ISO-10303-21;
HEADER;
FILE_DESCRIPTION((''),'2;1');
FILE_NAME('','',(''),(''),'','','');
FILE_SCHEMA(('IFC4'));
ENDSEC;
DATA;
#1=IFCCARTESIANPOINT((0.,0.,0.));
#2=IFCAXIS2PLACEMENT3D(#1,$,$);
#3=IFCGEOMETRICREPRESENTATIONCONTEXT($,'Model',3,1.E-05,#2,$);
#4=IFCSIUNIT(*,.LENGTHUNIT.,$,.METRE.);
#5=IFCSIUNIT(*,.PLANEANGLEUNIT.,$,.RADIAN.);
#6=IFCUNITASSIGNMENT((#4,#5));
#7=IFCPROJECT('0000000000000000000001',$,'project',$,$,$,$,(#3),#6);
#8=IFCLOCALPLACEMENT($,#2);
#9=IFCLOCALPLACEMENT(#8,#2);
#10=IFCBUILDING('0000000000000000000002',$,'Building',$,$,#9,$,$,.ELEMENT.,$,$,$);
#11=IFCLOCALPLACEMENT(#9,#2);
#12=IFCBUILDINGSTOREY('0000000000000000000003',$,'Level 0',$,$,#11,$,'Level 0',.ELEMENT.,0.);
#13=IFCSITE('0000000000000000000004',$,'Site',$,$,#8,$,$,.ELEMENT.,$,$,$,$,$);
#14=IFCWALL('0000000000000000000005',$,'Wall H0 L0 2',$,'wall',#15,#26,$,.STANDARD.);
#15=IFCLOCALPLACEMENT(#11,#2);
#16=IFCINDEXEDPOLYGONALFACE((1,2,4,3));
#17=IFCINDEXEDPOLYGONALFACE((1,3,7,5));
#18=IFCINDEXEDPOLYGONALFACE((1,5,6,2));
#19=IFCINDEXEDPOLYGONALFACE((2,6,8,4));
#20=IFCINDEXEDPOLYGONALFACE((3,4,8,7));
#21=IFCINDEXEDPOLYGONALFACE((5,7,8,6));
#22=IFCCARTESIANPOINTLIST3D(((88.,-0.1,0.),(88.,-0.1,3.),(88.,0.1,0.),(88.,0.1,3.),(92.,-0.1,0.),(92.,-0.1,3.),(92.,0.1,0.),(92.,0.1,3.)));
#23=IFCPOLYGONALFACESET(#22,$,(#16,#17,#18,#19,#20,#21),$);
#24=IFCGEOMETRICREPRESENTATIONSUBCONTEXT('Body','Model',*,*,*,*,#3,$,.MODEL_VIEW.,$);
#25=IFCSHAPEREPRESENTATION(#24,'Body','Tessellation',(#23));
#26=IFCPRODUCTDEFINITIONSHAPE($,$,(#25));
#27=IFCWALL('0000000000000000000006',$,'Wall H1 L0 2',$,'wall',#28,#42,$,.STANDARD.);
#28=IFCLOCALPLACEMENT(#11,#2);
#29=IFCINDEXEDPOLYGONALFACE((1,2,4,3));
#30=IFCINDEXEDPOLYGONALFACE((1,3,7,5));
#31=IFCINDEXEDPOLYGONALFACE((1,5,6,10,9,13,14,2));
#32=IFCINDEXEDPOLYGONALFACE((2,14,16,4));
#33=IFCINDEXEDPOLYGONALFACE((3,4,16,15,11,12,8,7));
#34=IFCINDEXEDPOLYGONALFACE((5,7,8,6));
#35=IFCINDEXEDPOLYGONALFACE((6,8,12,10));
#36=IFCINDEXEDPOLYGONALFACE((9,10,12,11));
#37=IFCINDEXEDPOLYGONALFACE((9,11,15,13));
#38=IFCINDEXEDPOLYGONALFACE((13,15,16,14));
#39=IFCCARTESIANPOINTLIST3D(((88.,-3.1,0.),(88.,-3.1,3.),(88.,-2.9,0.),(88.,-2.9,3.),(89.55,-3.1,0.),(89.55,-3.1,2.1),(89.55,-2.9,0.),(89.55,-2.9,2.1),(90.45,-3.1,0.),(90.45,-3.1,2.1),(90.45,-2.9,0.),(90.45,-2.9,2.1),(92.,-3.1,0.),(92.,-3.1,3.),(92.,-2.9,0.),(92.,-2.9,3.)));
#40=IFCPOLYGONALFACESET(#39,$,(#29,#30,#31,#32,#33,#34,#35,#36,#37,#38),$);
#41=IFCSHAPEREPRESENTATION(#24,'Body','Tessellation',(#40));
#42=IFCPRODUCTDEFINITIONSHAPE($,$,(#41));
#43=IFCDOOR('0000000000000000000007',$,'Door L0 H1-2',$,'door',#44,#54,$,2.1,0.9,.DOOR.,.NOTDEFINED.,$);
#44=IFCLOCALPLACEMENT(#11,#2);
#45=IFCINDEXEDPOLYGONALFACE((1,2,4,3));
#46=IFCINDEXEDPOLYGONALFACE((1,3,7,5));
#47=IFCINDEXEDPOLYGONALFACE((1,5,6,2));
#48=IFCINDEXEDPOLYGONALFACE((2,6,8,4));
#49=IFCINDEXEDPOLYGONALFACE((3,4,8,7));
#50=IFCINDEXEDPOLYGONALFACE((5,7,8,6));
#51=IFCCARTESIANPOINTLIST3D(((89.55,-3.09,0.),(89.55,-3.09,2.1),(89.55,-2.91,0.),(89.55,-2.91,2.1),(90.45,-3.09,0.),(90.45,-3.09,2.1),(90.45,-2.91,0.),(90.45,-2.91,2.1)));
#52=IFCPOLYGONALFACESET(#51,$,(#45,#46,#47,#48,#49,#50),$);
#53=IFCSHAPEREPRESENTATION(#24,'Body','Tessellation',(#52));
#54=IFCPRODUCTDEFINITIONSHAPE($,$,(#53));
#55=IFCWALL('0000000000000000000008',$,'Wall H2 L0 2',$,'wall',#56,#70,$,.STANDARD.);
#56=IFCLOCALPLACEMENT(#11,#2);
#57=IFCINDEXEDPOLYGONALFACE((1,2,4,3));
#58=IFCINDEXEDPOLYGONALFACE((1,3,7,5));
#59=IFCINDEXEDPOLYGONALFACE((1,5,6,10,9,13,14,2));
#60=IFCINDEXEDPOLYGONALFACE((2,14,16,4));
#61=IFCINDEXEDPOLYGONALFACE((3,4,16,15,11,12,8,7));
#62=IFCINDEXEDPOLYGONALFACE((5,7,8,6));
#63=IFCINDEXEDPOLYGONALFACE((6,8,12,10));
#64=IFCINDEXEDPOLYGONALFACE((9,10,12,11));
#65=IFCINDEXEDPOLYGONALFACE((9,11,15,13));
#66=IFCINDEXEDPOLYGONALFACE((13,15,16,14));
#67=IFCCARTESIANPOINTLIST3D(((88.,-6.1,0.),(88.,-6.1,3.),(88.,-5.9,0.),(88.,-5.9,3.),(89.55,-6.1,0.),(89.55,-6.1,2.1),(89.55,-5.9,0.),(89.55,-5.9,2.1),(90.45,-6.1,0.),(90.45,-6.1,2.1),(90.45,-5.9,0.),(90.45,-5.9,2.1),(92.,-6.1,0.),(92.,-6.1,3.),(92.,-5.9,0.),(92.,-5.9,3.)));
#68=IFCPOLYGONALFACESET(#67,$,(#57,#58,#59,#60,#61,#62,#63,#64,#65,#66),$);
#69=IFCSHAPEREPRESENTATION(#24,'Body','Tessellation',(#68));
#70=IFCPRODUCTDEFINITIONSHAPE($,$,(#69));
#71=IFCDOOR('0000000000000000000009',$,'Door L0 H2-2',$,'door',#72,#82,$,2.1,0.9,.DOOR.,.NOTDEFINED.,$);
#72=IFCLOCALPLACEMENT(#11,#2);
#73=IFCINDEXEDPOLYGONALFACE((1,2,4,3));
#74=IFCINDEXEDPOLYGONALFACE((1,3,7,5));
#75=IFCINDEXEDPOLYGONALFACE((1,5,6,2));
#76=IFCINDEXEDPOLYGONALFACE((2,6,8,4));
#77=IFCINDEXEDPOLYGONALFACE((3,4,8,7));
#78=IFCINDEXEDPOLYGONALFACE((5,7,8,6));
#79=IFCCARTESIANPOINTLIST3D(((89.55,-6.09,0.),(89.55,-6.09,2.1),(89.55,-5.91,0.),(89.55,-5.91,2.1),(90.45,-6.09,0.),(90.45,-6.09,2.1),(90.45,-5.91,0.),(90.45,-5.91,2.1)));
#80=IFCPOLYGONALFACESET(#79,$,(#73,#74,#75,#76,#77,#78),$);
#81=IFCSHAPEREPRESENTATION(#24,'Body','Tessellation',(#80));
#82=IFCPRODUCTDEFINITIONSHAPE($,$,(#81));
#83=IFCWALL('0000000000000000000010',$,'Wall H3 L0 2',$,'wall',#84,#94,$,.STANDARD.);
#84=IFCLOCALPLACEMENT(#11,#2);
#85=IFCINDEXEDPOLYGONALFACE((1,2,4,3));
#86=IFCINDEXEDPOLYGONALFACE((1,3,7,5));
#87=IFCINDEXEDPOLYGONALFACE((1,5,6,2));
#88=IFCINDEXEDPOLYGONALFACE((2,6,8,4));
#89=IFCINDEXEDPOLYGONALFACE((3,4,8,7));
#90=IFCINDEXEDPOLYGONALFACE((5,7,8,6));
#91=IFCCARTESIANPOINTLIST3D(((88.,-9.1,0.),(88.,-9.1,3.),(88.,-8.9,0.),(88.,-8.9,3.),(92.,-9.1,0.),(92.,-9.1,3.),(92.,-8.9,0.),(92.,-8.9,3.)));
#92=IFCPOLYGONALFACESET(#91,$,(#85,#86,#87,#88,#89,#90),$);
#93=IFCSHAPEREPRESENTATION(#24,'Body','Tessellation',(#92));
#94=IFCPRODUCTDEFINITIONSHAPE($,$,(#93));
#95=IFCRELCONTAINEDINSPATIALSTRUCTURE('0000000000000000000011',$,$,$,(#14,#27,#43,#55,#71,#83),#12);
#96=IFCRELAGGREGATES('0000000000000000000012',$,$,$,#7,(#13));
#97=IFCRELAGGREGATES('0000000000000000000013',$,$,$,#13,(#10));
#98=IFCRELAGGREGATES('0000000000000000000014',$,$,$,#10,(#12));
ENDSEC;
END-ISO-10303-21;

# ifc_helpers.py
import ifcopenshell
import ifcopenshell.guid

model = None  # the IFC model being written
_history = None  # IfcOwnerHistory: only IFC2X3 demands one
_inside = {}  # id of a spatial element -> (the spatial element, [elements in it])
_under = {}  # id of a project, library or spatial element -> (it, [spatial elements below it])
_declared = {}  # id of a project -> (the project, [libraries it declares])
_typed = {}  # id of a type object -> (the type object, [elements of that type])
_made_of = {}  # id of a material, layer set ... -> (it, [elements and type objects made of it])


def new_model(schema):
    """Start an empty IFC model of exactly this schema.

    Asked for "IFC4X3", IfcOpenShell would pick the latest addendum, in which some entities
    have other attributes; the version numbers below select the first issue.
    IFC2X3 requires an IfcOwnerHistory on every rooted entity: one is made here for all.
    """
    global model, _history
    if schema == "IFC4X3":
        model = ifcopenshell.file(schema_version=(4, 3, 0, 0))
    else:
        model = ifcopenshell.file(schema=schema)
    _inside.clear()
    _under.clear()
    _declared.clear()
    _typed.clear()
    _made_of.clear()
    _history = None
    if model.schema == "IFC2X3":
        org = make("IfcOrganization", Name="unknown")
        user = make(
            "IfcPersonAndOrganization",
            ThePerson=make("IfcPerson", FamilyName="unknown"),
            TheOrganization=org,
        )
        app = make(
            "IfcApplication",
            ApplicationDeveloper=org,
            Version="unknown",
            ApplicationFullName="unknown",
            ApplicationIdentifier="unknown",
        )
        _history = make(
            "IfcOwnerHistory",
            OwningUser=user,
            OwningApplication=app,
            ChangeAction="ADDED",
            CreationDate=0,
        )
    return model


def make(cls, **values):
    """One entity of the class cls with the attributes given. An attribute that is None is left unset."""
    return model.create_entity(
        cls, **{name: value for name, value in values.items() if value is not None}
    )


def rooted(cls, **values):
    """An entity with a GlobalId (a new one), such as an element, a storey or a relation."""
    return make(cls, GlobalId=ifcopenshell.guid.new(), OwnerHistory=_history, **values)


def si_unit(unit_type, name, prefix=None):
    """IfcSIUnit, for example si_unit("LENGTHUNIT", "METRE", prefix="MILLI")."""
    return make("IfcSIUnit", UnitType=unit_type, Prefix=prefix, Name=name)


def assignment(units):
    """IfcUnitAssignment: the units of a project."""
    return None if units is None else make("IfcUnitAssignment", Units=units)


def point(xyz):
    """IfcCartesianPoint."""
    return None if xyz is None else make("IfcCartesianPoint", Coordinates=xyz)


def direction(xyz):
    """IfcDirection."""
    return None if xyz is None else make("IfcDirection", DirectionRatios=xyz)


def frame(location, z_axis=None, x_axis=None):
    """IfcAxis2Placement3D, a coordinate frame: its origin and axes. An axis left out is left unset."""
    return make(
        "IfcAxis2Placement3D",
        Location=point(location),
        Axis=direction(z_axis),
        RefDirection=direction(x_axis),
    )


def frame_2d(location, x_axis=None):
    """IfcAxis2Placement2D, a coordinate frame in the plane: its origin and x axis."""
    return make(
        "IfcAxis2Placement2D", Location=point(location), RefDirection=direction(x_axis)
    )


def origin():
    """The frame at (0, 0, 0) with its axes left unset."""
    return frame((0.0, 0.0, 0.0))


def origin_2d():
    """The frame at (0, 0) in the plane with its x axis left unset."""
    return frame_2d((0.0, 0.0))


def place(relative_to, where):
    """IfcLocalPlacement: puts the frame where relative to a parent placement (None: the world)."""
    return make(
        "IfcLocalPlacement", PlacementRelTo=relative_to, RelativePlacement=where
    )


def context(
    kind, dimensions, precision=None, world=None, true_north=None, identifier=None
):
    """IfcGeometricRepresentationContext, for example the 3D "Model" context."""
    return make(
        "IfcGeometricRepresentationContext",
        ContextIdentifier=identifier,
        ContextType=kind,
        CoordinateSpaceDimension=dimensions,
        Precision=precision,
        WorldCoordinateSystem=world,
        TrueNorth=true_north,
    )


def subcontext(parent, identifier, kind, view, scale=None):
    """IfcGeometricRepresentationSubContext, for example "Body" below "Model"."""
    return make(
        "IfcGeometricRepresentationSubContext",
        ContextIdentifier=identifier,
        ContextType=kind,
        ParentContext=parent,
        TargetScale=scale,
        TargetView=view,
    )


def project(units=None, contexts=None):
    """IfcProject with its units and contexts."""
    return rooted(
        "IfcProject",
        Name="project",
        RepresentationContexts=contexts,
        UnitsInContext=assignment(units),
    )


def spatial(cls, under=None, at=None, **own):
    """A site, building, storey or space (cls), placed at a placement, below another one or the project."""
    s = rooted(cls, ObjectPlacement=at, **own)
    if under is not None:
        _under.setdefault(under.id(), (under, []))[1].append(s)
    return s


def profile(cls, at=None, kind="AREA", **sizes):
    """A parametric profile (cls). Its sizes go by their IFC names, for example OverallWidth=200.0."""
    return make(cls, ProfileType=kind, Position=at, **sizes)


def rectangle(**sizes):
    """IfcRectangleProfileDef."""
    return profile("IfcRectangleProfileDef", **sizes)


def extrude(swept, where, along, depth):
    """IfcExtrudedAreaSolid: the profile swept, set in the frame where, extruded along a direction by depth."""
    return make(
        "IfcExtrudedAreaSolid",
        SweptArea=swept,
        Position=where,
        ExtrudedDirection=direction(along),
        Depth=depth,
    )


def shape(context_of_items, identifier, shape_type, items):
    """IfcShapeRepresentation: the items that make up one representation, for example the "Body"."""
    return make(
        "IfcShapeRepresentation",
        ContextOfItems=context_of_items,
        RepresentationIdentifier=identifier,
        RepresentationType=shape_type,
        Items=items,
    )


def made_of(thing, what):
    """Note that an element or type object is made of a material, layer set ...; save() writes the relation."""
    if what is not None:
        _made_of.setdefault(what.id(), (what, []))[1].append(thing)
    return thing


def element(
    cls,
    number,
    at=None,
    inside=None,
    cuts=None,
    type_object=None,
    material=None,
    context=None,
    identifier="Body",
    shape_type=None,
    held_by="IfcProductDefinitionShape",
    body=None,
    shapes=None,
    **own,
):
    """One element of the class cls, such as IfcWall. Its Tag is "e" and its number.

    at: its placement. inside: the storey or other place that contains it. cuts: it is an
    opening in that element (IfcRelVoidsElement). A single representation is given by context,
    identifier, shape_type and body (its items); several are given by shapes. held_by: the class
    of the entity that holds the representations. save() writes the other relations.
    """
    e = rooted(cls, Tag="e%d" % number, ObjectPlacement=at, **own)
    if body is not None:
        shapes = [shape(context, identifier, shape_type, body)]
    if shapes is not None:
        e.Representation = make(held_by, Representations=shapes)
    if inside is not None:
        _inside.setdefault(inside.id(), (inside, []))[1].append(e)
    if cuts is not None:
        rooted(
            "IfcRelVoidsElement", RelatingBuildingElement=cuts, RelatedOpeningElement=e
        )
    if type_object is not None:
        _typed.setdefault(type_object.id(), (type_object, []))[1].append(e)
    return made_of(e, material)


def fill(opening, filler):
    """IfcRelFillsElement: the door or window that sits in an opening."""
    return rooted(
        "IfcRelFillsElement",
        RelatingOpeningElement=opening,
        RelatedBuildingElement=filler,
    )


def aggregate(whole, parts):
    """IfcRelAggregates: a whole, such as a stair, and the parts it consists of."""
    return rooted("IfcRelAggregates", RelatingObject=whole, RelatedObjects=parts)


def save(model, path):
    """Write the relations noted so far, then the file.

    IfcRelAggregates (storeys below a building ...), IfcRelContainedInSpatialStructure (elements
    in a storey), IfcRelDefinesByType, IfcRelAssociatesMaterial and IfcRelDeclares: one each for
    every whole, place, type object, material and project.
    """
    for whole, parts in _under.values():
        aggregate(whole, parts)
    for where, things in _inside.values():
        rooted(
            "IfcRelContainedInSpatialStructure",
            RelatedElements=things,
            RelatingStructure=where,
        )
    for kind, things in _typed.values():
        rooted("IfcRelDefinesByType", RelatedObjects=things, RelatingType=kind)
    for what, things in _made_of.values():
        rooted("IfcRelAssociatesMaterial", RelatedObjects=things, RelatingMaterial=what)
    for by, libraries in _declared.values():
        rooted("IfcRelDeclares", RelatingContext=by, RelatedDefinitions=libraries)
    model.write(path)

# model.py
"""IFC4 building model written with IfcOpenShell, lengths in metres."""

from ifc_helpers import new_model, si_unit, frame, frame_2d, origin, origin_2d, place, context, subcontext, project, spatial, rectangle, extrude, element, fill, save


model = new_model("IFC4")

# Units and contexts
model_context = context("Model", 3, precision=1e-05, world=origin())
body_context = subcontext(model_context, "Body", "Model", "MODEL_VIEW")
ifc_project = project(units=[si_unit("LENGTHUNIT", "METRE"), si_unit("PLANEANGLEUNIT", "RADIAN")], contexts=[model_context])

# Site, building, storey
site_placement = place(None, origin())
site = spatial("IfcSite", under=ifc_project, at=site_placement, Name="Site", CompositionType="ELEMENT")
building_placement = place(site_placement, origin())
building = spatial("IfcBuilding", under=site, at=building_placement, Name="Building", CompositionType="ELEMENT")
storey_placement = place(building_placement, origin())
storey = spatial("IfcBuildingStorey", under=building, at=storey_placement, Name="Level 0", LongName="Level 0", CompositionType="ELEMENT", Elevation=0.0)

# Wall
wall_1_placement = place(storey_placement, frame((88.0, 0.0, 0.0), z_axis=(0.0, 0.0, 1.0), x_axis=(1.0, 0.0, 0.0)))
element("IfcWall", 1, at=wall_1_placement, inside=storey, Name="Wall H0 L0 2", ObjectType="wall", PredefinedType="STANDARD", context=body_context, shape_type="SweptSolid", body=[
    extrude(rectangle(XDim=4.0, YDim=0.2, at=frame_2d((2.0, 0.0))), origin(), (0.0, 0.0, 1.0), 3.0),
])

# Walls, openings, doors
wall_2_placement = place(storey_placement, frame((88.0, -3.0, 0.0), z_axis=(0.0, 0.0, 1.0), x_axis=(1.0, 0.0, 0.0)))
wall_2 = element("IfcWall", 2, at=wall_2_placement, inside=storey, Name="Wall H1 L0 2", ObjectType="wall", PredefinedType="STANDARD", context=body_context, shape_type="SweptSolid", body=[
    extrude(rectangle(XDim=4.0, YDim=0.2, at=frame_2d((2.0, 0.0))), origin(), (0.0, 0.0, 1.0), 3.0),
])
opening_1_placement = place(storey_placement, frame((90.0, -3.0, 0.0), z_axis=(0.0, 0.0, 1.0), x_axis=(1.0, 0.0, 0.0)))
opening_1 = element("IfcOpeningElement", 3, at=opening_1_placement, cuts=wall_2, ObjectType="Opening", PredefinedType="OPENING", context=body_context, shape_type="SweptSolid", body=[
    extrude(rectangle(XDim=0.9, YDim=0.22, at=origin_2d()), origin(), (0.0, 0.0, 1.0), 2.1),
])
door_1_placement = place(storey_placement, frame((90.0, -3.0, 0.0), z_axis=(0.0, 0.0, 1.0), x_axis=(1.0, 0.0, 0.0)))
door_1 = element("IfcDoor", 4, at=door_1_placement, inside=storey, Name="Door L0 H1-2", ObjectType="door", OperationType="NOTDEFINED", OverallHeight=2.1, OverallWidth=0.9, PredefinedType="DOOR", context=body_context, shape_type="SweptSolid", body=[
    extrude(rectangle(XDim=0.9, YDim=0.18, at=origin_2d()), origin(), (0.0, 0.0, 1.0), 2.1),
])
fill(opening_1, door_1)
wall_3_placement = place(storey_placement, frame((88.0, -6.0, 0.0), z_axis=(0.0, 0.0, 1.0), x_axis=(1.0, 0.0, 0.0)))
wall_3 = element("IfcWall", 5, at=wall_3_placement, inside=storey, Name="Wall H2 L0 2", ObjectType="wall", PredefinedType="STANDARD", context=body_context, shape_type="SweptSolid", body=[
    extrude(rectangle(XDim=4.0, YDim=0.2, at=frame_2d((2.0, 0.0))), origin(), (0.0, 0.0, 1.0), 3.0),
])
opening_2_placement = place(storey_placement, frame((90.0, -6.0, 0.0), z_axis=(0.0, 0.0, 1.0), x_axis=(1.0, 0.0, 0.0)))
opening_2 = element("IfcOpeningElement", 6, at=opening_2_placement, cuts=wall_3, ObjectType="Opening", PredefinedType="OPENING", context=body_context, shape_type="SweptSolid", body=[
    extrude(rectangle(XDim=0.9, YDim=0.22, at=origin_2d()), origin(), (0.0, 0.0, 1.0), 2.1),
])
door_2_placement = place(storey_placement, frame((90.0, -6.0, 0.0), z_axis=(0.0, 0.0, 1.0), x_axis=(1.0, 0.0, 0.0)))
door_2 = element("IfcDoor", 7, at=door_2_placement, inside=storey, Name="Door L0 H2-2", ObjectType="door", OperationType="NOTDEFINED", OverallHeight=2.1, OverallWidth=0.9, PredefinedType="DOOR", context=body_context, shape_type="SweptSolid", body=[
    extrude(rectangle(XDim=0.9, YDim=0.18, at=origin_2d()), origin(), (0.0, 0.0, 1.0), 2.1),
])
fill(opening_2, door_2)

# Wall
wall_4_placement = place(storey_placement, frame((88.0, -9.0, 0.0), z_axis=(0.0, 0.0, 1.0), x_axis=(1.0, 0.0, 0.0)))
element("IfcWall", 8, at=wall_4_placement, inside=storey, Name="Wall H3 L0 2", ObjectType="wall", PredefinedType="STANDARD", context=body_context, shape_type="SweptSolid", body=[
    extrude(rectangle(XDim=4.0, YDim=0.2, at=frame_2d((2.0, 0.0))), origin(), (0.0, 0.0, 1.0), 3.0),
])

save(model, "model.ifc")
